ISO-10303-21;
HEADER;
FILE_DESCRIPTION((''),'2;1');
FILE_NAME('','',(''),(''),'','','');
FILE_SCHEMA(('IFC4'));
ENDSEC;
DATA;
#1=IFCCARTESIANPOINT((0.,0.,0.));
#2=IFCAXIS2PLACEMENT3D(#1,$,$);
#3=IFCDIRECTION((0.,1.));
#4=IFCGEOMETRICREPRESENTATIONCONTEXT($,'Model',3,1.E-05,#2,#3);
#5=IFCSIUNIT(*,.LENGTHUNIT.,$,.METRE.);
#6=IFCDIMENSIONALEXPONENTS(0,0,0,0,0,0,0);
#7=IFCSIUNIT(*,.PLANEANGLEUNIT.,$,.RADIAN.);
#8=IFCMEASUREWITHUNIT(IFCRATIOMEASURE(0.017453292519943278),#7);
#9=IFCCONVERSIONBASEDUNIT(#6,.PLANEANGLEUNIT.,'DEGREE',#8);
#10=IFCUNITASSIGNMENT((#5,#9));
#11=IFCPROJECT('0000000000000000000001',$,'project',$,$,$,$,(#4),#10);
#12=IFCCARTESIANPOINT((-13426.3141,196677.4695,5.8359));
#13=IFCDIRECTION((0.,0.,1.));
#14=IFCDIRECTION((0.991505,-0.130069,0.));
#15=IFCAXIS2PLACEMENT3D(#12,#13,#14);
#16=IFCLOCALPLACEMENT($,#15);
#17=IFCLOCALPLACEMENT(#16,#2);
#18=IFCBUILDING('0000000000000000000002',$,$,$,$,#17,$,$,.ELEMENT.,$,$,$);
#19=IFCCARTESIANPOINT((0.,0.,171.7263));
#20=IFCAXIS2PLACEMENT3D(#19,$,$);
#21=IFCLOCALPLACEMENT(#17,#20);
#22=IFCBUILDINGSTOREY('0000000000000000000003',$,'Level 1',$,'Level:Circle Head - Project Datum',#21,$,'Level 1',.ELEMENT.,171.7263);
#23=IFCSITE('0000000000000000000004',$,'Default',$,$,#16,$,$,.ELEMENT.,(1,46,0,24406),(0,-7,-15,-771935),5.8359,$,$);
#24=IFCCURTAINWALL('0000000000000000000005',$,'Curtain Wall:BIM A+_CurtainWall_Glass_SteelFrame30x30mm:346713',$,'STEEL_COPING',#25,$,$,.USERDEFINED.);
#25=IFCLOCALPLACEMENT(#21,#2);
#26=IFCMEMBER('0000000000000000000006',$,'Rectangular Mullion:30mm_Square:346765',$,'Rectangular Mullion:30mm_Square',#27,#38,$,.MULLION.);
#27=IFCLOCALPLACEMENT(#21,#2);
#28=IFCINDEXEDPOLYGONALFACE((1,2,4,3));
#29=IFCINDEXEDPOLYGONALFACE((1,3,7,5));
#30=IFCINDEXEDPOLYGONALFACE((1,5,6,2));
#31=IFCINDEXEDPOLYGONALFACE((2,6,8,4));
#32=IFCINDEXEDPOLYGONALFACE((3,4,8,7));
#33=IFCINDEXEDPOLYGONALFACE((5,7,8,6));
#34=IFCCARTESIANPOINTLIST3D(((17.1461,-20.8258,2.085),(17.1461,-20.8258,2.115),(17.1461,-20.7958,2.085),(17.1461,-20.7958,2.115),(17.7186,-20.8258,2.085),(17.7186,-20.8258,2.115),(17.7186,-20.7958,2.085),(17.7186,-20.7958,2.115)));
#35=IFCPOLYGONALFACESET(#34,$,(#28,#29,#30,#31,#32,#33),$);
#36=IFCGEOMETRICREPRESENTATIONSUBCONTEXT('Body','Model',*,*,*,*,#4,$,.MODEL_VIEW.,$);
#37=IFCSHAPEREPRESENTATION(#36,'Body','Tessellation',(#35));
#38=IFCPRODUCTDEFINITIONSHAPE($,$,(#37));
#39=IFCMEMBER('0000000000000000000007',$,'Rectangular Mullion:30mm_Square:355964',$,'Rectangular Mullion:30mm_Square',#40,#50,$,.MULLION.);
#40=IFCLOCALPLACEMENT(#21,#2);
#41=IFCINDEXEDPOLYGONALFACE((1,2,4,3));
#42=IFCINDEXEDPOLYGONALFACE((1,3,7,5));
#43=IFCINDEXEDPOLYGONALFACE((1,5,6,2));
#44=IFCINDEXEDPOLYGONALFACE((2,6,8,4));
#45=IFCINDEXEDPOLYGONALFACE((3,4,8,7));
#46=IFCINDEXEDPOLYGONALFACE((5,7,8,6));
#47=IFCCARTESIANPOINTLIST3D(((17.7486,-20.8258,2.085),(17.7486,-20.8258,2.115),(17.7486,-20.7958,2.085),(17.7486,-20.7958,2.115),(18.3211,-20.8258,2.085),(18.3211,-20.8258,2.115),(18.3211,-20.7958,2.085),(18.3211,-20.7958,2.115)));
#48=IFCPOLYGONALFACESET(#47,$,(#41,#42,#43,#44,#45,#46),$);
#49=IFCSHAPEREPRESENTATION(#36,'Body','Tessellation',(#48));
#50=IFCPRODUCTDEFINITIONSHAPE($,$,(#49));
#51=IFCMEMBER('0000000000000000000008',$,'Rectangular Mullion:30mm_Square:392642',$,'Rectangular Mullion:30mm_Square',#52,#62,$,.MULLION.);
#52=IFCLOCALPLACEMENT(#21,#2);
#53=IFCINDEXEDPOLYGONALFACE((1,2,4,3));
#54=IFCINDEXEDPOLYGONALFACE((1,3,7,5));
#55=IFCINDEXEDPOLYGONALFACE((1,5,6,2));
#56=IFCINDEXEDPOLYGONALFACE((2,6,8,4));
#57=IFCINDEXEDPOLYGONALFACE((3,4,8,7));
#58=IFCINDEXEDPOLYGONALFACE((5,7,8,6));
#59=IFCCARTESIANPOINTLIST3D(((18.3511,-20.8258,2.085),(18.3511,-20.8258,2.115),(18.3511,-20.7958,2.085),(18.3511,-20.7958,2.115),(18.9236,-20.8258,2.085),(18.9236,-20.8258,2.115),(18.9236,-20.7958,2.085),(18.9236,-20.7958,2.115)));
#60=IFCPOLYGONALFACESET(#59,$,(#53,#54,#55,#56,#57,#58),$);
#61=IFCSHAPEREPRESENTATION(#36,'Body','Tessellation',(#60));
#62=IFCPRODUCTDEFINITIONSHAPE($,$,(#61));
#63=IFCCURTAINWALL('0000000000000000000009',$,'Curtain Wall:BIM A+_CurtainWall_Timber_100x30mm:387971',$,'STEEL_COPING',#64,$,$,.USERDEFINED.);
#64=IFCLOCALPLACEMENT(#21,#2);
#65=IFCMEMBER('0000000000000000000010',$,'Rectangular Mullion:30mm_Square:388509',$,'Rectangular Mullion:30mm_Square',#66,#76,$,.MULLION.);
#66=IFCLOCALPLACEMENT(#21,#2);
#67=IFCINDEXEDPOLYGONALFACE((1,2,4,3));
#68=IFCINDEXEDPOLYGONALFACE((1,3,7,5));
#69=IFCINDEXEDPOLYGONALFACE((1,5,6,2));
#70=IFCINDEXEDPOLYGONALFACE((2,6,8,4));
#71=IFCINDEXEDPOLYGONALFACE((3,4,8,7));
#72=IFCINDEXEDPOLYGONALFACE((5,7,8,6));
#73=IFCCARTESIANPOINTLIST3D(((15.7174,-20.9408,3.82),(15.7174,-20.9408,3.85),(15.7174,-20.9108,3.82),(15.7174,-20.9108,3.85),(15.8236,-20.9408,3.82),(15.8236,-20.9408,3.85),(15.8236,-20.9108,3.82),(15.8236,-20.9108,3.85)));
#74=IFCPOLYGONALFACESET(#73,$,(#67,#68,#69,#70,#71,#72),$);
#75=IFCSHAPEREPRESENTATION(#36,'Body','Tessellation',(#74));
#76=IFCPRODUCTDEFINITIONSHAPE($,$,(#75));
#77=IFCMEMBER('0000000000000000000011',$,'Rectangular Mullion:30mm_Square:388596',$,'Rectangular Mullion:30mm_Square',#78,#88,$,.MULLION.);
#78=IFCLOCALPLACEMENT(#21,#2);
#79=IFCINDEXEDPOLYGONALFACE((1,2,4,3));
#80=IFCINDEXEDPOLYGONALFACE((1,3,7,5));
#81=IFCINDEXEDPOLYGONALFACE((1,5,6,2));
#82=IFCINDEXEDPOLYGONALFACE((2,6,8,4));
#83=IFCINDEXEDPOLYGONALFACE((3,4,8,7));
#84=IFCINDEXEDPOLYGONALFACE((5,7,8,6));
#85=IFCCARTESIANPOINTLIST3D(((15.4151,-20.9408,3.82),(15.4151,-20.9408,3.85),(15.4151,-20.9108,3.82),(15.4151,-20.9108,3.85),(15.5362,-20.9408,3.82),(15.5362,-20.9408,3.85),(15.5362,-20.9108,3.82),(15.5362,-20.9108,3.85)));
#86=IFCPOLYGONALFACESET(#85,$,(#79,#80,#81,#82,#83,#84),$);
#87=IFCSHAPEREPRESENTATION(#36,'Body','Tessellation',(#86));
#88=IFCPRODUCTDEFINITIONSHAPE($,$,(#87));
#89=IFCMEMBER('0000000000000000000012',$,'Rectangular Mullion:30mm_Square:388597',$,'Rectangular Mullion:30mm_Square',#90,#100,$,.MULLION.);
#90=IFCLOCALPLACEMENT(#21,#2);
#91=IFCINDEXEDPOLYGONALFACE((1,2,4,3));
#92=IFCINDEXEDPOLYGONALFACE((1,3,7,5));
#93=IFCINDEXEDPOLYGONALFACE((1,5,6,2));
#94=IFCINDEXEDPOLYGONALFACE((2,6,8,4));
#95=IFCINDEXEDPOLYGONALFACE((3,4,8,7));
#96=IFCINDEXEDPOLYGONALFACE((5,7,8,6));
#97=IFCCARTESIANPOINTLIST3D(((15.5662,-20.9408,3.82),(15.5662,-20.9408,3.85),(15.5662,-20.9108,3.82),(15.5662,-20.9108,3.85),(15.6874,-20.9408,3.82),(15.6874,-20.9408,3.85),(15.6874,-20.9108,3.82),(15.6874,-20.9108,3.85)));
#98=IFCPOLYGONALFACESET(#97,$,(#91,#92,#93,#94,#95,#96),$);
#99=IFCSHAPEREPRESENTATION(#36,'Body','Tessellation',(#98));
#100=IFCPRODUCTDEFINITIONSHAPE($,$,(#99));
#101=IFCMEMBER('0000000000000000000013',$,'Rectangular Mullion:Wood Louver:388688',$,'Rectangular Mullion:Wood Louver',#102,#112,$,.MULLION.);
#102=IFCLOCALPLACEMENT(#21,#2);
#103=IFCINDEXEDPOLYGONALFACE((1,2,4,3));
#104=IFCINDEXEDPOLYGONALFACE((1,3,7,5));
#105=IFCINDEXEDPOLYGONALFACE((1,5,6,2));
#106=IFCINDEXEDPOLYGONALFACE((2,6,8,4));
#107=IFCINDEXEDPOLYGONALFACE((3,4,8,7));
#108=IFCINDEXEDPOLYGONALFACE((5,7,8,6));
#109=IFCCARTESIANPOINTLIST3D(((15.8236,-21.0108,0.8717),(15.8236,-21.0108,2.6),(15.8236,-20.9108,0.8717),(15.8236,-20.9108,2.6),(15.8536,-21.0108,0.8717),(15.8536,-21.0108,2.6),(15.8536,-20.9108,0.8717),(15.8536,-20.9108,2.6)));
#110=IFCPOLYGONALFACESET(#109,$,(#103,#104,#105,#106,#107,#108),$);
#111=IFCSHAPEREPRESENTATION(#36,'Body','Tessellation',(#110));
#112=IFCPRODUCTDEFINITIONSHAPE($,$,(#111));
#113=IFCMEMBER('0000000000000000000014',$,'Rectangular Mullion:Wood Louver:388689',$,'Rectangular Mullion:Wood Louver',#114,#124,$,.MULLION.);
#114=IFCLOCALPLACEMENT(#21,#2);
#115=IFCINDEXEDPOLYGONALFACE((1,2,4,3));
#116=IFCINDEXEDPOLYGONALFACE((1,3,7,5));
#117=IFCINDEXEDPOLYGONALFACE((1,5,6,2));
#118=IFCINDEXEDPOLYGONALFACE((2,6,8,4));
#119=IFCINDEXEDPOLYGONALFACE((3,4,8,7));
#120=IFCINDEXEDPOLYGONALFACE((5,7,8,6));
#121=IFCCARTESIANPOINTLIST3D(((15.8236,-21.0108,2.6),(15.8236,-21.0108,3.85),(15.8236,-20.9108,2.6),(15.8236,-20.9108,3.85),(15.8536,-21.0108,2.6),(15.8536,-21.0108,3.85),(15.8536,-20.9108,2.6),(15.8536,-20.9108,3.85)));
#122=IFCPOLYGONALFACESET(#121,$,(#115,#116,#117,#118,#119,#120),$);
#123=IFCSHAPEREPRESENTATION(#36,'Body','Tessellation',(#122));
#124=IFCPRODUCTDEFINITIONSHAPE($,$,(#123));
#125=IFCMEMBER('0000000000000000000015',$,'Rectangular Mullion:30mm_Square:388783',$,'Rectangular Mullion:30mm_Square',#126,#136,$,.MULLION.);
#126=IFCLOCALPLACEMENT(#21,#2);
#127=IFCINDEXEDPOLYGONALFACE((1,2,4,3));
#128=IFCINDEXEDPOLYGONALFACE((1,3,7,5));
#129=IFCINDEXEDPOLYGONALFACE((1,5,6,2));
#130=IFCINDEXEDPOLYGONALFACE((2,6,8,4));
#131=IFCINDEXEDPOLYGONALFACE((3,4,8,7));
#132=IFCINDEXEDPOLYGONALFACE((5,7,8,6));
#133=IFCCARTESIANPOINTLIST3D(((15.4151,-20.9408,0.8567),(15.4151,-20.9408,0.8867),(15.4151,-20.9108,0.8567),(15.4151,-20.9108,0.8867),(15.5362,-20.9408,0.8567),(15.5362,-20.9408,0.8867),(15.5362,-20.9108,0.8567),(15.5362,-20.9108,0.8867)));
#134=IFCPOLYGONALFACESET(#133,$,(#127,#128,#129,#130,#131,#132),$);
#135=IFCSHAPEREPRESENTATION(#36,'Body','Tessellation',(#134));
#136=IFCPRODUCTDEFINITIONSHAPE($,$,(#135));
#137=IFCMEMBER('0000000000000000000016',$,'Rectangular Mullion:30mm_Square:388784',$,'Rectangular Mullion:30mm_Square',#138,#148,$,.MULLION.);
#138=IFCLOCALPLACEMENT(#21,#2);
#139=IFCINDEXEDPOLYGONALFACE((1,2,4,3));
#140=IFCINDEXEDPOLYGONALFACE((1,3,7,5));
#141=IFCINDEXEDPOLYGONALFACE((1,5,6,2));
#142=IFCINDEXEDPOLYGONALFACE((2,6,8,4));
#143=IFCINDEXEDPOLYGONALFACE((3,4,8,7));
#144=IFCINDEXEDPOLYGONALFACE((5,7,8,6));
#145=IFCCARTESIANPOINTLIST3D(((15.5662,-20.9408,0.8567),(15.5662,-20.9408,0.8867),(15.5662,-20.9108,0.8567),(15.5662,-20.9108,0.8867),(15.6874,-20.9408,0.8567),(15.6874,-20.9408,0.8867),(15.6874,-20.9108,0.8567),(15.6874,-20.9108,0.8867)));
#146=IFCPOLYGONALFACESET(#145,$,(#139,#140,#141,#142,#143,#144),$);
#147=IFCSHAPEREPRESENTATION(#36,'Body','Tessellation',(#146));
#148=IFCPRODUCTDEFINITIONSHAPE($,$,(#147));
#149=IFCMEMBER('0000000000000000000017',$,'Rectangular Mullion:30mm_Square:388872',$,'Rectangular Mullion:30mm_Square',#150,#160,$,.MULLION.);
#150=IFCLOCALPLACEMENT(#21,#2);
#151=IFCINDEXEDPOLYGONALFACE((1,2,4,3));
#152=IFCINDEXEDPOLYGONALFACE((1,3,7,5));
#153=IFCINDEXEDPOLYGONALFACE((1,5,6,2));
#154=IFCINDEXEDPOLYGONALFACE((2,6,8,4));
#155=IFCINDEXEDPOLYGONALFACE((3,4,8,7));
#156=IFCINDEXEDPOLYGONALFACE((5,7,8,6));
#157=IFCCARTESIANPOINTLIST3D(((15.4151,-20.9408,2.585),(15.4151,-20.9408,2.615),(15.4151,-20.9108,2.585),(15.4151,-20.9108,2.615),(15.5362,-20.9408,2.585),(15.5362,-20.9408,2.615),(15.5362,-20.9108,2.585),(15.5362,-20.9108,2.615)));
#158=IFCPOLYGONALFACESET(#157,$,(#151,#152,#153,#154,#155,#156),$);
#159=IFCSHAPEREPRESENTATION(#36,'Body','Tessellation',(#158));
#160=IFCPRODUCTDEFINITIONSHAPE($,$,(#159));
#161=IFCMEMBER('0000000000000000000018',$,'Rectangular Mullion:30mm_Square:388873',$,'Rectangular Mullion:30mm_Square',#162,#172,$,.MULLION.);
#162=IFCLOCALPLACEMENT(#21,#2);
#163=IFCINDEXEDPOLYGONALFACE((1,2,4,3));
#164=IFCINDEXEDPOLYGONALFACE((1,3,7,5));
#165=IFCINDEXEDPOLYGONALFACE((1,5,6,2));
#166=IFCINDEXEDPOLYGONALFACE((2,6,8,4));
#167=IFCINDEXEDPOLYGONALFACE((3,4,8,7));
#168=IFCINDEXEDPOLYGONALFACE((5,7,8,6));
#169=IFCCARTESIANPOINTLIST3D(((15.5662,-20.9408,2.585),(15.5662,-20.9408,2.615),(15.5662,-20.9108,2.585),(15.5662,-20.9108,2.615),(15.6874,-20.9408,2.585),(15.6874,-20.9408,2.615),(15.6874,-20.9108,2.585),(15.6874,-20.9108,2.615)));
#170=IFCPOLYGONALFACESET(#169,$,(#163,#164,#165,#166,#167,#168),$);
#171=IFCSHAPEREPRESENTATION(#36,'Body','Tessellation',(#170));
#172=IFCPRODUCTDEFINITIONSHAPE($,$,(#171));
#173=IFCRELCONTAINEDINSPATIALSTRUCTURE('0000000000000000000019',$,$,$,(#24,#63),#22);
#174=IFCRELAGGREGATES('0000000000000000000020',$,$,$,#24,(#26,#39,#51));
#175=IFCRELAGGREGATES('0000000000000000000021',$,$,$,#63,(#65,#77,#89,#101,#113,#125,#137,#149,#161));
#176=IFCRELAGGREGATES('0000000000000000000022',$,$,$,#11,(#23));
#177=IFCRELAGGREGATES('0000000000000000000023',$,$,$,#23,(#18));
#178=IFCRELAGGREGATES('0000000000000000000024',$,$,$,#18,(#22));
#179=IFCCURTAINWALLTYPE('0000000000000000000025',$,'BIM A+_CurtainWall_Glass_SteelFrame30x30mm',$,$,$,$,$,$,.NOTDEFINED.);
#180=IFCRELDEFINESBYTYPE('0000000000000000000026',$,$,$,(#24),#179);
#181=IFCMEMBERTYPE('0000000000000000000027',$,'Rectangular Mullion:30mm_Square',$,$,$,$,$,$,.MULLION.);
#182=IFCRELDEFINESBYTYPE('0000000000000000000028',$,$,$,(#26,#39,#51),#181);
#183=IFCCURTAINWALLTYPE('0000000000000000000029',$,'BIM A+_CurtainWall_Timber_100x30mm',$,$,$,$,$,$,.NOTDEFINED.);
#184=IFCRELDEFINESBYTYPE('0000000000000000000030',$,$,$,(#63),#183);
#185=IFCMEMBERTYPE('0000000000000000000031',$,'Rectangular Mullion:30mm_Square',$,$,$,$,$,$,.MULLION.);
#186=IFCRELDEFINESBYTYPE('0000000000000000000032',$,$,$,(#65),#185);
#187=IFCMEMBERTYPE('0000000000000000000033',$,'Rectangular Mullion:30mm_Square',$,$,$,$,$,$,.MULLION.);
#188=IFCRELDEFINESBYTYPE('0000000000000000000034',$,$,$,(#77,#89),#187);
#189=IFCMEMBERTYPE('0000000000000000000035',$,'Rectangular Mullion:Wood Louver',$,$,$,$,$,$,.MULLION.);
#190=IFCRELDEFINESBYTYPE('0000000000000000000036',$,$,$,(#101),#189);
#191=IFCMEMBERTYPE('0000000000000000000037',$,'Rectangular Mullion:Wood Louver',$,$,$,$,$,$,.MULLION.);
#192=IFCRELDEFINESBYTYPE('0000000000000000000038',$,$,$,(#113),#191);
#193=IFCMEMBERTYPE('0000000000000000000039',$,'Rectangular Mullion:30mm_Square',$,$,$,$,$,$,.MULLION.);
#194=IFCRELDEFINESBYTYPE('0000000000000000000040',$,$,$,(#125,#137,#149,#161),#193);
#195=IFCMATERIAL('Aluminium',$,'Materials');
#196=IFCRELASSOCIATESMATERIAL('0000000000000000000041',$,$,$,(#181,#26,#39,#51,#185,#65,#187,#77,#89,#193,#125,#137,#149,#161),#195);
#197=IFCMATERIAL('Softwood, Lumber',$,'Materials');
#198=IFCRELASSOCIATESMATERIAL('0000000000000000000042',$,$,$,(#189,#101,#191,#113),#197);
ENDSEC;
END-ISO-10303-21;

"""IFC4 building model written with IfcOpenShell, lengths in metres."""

from ifc_helpers import new_model, entity, si_unit, converted_unit, direction, frame, origin, place, context, subcontext, project, spatial, indexed_curve, outline, extrude, source, transform, mapped, material, type_object, type_shapes, element, aggregate, save


model = new_model("IFC4")

# Units and contexts
model_context = context("Model", 3, precision=1e-05, world=origin(), true_north=direction((0.0, 1.0)))
body_context = subcontext(model_context, "Body", "Model", "MODEL_VIEW")
ifc_project = project(units=[si_unit("LENGTHUNIT", "METRE"), converted_unit("PLANEANGLEUNIT", "DEGREE", entity("IfcRatioMeasure", 0.017453292519943278), si_unit("PLANEANGLEUNIT", "RADIAN"), dimensions=[0, 0, 0, 0, 0, 0, 0])], contexts=[model_context])

# Site, building, storey
site_placement = place(None, frame((-13426.3141, 196677.4695, 5.8359), z_axis=(0.0, 0.0, 1.0), x_axis=(0.991505, -0.130069, 0.0)))
site = spatial("IfcSite", under=ifc_project, at=site_placement, Name="Default", CompositionType="ELEMENT", RefLatitude=(1, 46, 0, 24406), RefLongitude=(0, -7, -15, -771935), RefElevation=5.8359)
building_placement = place(site_placement, origin())
building = spatial("IfcBuilding", under=site, at=building_placement, CompositionType="ELEMENT")
storey_placement = place(building_placement, frame((0.0, 0.0, 171.7263)))
storey = spatial("IfcBuildingStorey", under=building, at=storey_placement, Name="Level 1", ObjectType="Level:Circle Head - Project Datum", LongName="Level 1", CompositionType="ELEMENT", Elevation=171.7263)

# Curtain walls, members
curtain_wall_type_1 = type_object("IfcCurtainWallType", Name="BIM A+_CurtainWall_Glass_SteelFrame30x30mm", PredefinedType="NOTDEFINED")
curtain_wall_1_placement = place(storey_placement, frame((0.0, 0.0, -171.7263)))
curtain_wall_1 = element("IfcCurtainWall", 1, at=curtain_wall_1_placement, inside=storey, type_object=curtain_wall_type_1, Name="Curtain Wall:BIM A+_CurtainWall_Glass_SteelFrame30x30mm:346713", ObjectType="STEEL_COPING", PredefinedType="USERDEFINED")
ifc_material_1 = material(Name="Aluminium", Category="Materials")
member_type_1 = type_object("IfcMemberType", Name="Rectangular Mullion:30mm_Square", PredefinedType="MULLION", material=ifc_material_1)
shared_shape_1 = source(origin(), body_context, "Body", "SweptSolid", [
    extrude(outline(indexed_curve([(-0.015, -0.015), (0.015, -0.015), (0.015, 0.015), (-0.015, 0.015), (-0.015, -0.015)], self_intersect=False)), frame((0.0, 0.0, -0.5725), z_axis=(0.0, 0.0, 1.0), x_axis=(0.0, -1.0, 0.0)), (0.0, 0.0, 1.0), 0.5725),
])
type_shapes(member_type_1, [shared_shape_1])
member_1_placement = place(curtain_wall_1_placement, frame((17.7186, -20.8108, 173.8263), z_axis=(1.0, 0.0, 0.0), x_axis=(0.0, 0.0, 1.0)))
member_1 = element("IfcMember", 2, at=member_1_placement, type_object=member_type_1, material=ifc_material_1, Name="Rectangular Mullion:30mm_Square:346765", ObjectType="Rectangular Mullion:30mm_Square", PredefinedType="MULLION", context=body_context, shape_type="MappedRepresentation", body=[
    mapped(shared_shape_1, transform((0.0, 0.0, 0.0), scale=1.0)),
])
member_2_placement = place(curtain_wall_1_placement, frame((18.3211, -20.8108, 173.8263), z_axis=(1.0, 0.0, 0.0), x_axis=(0.0, 0.0, 1.0)))
member_2 = element("IfcMember", 3, at=member_2_placement, type_object=member_type_1, material=ifc_material_1, Name="Rectangular Mullion:30mm_Square:355964", ObjectType="Rectangular Mullion:30mm_Square", PredefinedType="MULLION", context=body_context, shape_type="MappedRepresentation", body=[
    mapped(shared_shape_1, transform((0.0, 0.0, 0.0), scale=1.0)),
])
member_3_placement = place(curtain_wall_1_placement, frame((18.9236, -20.8108, 173.8263), z_axis=(1.0, 0.0, 0.0), x_axis=(0.0, 0.0, 1.0)))
member_3 = element("IfcMember", 4, at=member_3_placement, type_object=member_type_1, material=ifc_material_1, Name="Rectangular Mullion:30mm_Square:392642", ObjectType="Rectangular Mullion:30mm_Square", PredefinedType="MULLION", context=body_context, shape_type="MappedRepresentation", body=[
    mapped(shared_shape_1, transform((0.0, 0.0, 0.0), scale=1.0)),
])
curtain_wall_type_2 = type_object("IfcCurtainWallType", Name="BIM A+_CurtainWall_Timber_100x30mm", PredefinedType="NOTDEFINED")
curtain_wall_2_placement = place(storey_placement, frame((0.0, 0.0, -171.7263)))
curtain_wall_2 = element("IfcCurtainWall", 5, at=curtain_wall_2_placement, inside=storey, type_object=curtain_wall_type_2, Name="Curtain Wall:BIM A+_CurtainWall_Timber_100x30mm:387971", ObjectType="STEEL_COPING", PredefinedType="USERDEFINED")
member_type_2 = type_object("IfcMemberType", Name="Rectangular Mullion:30mm_Square", PredefinedType="MULLION", material=ifc_material_1)
shared_shape_2 = source(origin(), body_context, "Body", "SweptSolid", [
    extrude(outline(indexed_curve([(-0.015, -0.015), (0.015, -0.015), (0.015, 0.015), (-0.015, 0.015), (-0.015, -0.015)], self_intersect=False)), frame((-0.015, 0.0, -0.1062), z_axis=(0.0, 0.0, 1.0), x_axis=(0.0, -1.0, 0.0)), (0.0, 0.0, 1.0), 0.1062),
])
type_shapes(member_type_2, [shared_shape_2])
member_4_placement = place(curtain_wall_2_placement, frame((15.8236, -20.9258, 175.5763), z_axis=(1.0, 0.0, 0.0), x_axis=(0.0, 0.0, 1.0)))
member_4 = element("IfcMember", 6, at=member_4_placement, type_object=member_type_2, material=ifc_material_1, Name="Rectangular Mullion:30mm_Square:388509", ObjectType="Rectangular Mullion:30mm_Square", PredefinedType="MULLION", context=body_context, shape_type="MappedRepresentation", body=[
    mapped(shared_shape_2, transform((0.0, 0.0, 0.0), scale=1.0)),
])
member_type_3 = type_object("IfcMemberType", Name="Rectangular Mullion:30mm_Square", PredefinedType="MULLION", material=ifc_material_1)
shared_shape_3 = source(origin(), body_context, "Body", "SweptSolid", [
    extrude(outline(indexed_curve([(-0.015, -0.015), (0.015, -0.015), (0.015, 0.015), (-0.015, 0.015), (-0.015, -0.015)], self_intersect=False)), frame((-0.015, 0.0, -0.1212), z_axis=(0.0, 0.0, 1.0), x_axis=(0.0, -1.0, 0.0)), (0.0, 0.0, 1.0), 0.1212),
])
type_shapes(member_type_3, [shared_shape_3])
member_5_placement = place(curtain_wall_2_placement, frame((15.5362, -20.9258, 175.5763), z_axis=(1.0, 0.0, 0.0), x_axis=(0.0, 0.0, 1.0)))
member_5 = element("IfcMember", 7, at=member_5_placement, type_object=member_type_3, material=ifc_material_1, Name="Rectangular Mullion:30mm_Square:388596", ObjectType="Rectangular Mullion:30mm_Square", PredefinedType="MULLION", context=body_context, shape_type="MappedRepresentation", body=[
    mapped(shared_shape_3, transform((0.0, 0.0, 0.0), scale=1.0)),
])
member_6_placement = place(curtain_wall_2_placement, frame((15.6874, -20.9258, 175.5763), z_axis=(1.0, 0.0, 0.0), x_axis=(0.0, 0.0, 1.0)))
member_6 = element("IfcMember", 8, at=member_6_placement, type_object=member_type_3, material=ifc_material_1, Name="Rectangular Mullion:30mm_Square:388597", ObjectType="Rectangular Mullion:30mm_Square", PredefinedType="MULLION", context=body_context, shape_type="MappedRepresentation", body=[
    mapped(shared_shape_3, transform((0.0, 0.0, 0.0), scale=1.0)),
])
ifc_material_2 = material(Name="Softwood, Lumber", Category="Materials")
member_type_4 = type_object("IfcMemberType", Name="Rectangular Mullion:Wood Louver", PredefinedType="MULLION", material=ifc_material_2)
shared_shape_4 = source(origin(), body_context, "Body", "SweptSolid", [
    extrude(outline(indexed_curve([(-0.05, -0.015), (0.05, -0.015), (0.05, 0.015), (-0.05, 0.015), (-0.05, -0.015)], self_intersect=False)), frame((-0.015, 0.035, -1.7283), z_axis=(0.0, 0.0, 1.0), x_axis=(0.0, -1.0, 0.0)), (0.0, 0.0, 1.0), 1.7283),
])
type_shapes(member_type_4, [shared_shape_4])
member_7_placement = place(curtain_wall_2_placement, frame((15.8536, -20.9258, 172.598), z_axis=(0.0, 0.0, -1.0), x_axis=(1.0, 0.0, 0.0)))
member_7 = element("IfcMember", 9, at=member_7_placement, type_object=member_type_4, material=ifc_material_2, Name="Rectangular Mullion:Wood Louver:388688", ObjectType="Rectangular Mullion:Wood Louver", PredefinedType="MULLION", context=body_context, shape_type="MappedRepresentation", body=[
    mapped(shared_shape_4, transform((0.0, 0.0, 0.0), scale=1.0)),
])
member_type_5 = type_object("IfcMemberType", Name="Rectangular Mullion:Wood Louver", PredefinedType="MULLION", material=ifc_material_2)
shared_shape_5 = source(origin(), body_context, "Body", "SweptSolid", [
    extrude(outline(indexed_curve([(-0.05, -0.015), (0.05, -0.015), (0.05, 0.015), (-0.05, 0.015), (-0.05, -0.015)], self_intersect=False)), frame((-0.015, 0.035, -1.25), z_axis=(0.0, 0.0, 1.0), x_axis=(0.0, -1.0, 0.0)), (0.0, 0.0, 1.0), 1.25),
])
type_shapes(member_type_5, [shared_shape_5])
member_8_placement = place(curtain_wall_2_placement, frame((15.8536, -20.9258, 174.3263), z_axis=(0.0, 0.0, -1.0), x_axis=(1.0, 0.0, 0.0)))
member_8 = element("IfcMember", 10, at=member_8_placement, type_object=member_type_5, material=ifc_material_2, Name="Rectangular Mullion:Wood Louver:388689", ObjectType="Rectangular Mullion:Wood Louver", PredefinedType="MULLION", context=body_context, shape_type="MappedRepresentation", body=[
    mapped(shared_shape_5, transform((0.0, 0.0, 0.0), scale=1.0)),
])
member_type_6 = type_object("IfcMemberType", Name="Rectangular Mullion:30mm_Square", PredefinedType="MULLION", material=ifc_material_1)
shared_shape_6 = source(origin(), body_context, "Body", "SweptSolid", [
    extrude(outline(indexed_curve([(-0.015, -0.015), (0.015, -0.015), (0.015, 0.015), (-0.015, 0.015), (-0.015, -0.015)], self_intersect=False)), frame((0.0, 0.0, -0.1212), z_axis=(0.0, 0.0, 1.0), x_axis=(0.0, -1.0, 0.0)), (0.0, 0.0, 1.0), 0.1212),
])
type_shapes(member_type_6, [shared_shape_6])
member_9_placement = place(curtain_wall_2_placement, frame((15.5362, -20.9258, 172.598), z_axis=(1.0, 0.0, 0.0), x_axis=(0.0, 0.0, 1.0)))
member_9 = element("IfcMember", 11, at=member_9_placement, type_object=member_type_6, material=ifc_material_1, Name="Rectangular Mullion:30mm_Square:388783", ObjectType="Rectangular Mullion:30mm_Square", PredefinedType="MULLION", context=body_context, shape_type="MappedRepresentation", body=[
    mapped(shared_shape_6, transform((0.0, 0.0, 0.0), scale=1.0)),
])
member_10_placement = place(curtain_wall_2_placement, frame((15.6874, -20.9258, 172.598), z_axis=(1.0, 0.0, 0.0), x_axis=(0.0, 0.0, 1.0)))
member_10 = element("IfcMember", 12, at=member_10_placement, type_object=member_type_6, material=ifc_material_1, Name="Rectangular Mullion:30mm_Square:388784", ObjectType="Rectangular Mullion:30mm_Square", PredefinedType="MULLION", context=body_context, shape_type="MappedRepresentation", body=[
    mapped(shared_shape_6, transform((0.0, 0.0, 0.0), scale=1.0)),
])
member_11_placement = place(curtain_wall_2_placement, frame((15.5362, -20.9258, 174.3263), z_axis=(1.0, 0.0, 0.0), x_axis=(0.0, 0.0, 1.0)))
member_11 = element("IfcMember", 13, at=member_11_placement, type_object=member_type_6, material=ifc_material_1, Name="Rectangular Mullion:30mm_Square:388872", ObjectType="Rectangular Mullion:30mm_Square", PredefinedType="MULLION", context=body_context, shape_type="MappedRepresentation", body=[
    mapped(shared_shape_6, transform((0.0, 0.0, 0.0), scale=1.0)),
])
member_12_placement = place(curtain_wall_2_placement, frame((15.6874, -20.9258, 174.3263), z_axis=(1.0, 0.0, 0.0), x_axis=(0.0, 0.0, 1.0)))
member_12 = element("IfcMember", 14, at=member_12_placement, type_object=member_type_6, material=ifc_material_1, Name="Rectangular Mullion:30mm_Square:388873", ObjectType="Rectangular Mullion:30mm_Square", PredefinedType="MULLION", context=body_context, shape_type="MappedRepresentation", body=[
    mapped(shared_shape_6, transform((0.0, 0.0, 0.0), scale=1.0)),
])

aggregate(curtain_wall_1, [member_1, member_2, member_3])
aggregate(curtain_wall_2, [member_4, member_5, member_6, member_7, member_8, member_9, member_10, member_11, member_12])

save(model, "model.ifc")
